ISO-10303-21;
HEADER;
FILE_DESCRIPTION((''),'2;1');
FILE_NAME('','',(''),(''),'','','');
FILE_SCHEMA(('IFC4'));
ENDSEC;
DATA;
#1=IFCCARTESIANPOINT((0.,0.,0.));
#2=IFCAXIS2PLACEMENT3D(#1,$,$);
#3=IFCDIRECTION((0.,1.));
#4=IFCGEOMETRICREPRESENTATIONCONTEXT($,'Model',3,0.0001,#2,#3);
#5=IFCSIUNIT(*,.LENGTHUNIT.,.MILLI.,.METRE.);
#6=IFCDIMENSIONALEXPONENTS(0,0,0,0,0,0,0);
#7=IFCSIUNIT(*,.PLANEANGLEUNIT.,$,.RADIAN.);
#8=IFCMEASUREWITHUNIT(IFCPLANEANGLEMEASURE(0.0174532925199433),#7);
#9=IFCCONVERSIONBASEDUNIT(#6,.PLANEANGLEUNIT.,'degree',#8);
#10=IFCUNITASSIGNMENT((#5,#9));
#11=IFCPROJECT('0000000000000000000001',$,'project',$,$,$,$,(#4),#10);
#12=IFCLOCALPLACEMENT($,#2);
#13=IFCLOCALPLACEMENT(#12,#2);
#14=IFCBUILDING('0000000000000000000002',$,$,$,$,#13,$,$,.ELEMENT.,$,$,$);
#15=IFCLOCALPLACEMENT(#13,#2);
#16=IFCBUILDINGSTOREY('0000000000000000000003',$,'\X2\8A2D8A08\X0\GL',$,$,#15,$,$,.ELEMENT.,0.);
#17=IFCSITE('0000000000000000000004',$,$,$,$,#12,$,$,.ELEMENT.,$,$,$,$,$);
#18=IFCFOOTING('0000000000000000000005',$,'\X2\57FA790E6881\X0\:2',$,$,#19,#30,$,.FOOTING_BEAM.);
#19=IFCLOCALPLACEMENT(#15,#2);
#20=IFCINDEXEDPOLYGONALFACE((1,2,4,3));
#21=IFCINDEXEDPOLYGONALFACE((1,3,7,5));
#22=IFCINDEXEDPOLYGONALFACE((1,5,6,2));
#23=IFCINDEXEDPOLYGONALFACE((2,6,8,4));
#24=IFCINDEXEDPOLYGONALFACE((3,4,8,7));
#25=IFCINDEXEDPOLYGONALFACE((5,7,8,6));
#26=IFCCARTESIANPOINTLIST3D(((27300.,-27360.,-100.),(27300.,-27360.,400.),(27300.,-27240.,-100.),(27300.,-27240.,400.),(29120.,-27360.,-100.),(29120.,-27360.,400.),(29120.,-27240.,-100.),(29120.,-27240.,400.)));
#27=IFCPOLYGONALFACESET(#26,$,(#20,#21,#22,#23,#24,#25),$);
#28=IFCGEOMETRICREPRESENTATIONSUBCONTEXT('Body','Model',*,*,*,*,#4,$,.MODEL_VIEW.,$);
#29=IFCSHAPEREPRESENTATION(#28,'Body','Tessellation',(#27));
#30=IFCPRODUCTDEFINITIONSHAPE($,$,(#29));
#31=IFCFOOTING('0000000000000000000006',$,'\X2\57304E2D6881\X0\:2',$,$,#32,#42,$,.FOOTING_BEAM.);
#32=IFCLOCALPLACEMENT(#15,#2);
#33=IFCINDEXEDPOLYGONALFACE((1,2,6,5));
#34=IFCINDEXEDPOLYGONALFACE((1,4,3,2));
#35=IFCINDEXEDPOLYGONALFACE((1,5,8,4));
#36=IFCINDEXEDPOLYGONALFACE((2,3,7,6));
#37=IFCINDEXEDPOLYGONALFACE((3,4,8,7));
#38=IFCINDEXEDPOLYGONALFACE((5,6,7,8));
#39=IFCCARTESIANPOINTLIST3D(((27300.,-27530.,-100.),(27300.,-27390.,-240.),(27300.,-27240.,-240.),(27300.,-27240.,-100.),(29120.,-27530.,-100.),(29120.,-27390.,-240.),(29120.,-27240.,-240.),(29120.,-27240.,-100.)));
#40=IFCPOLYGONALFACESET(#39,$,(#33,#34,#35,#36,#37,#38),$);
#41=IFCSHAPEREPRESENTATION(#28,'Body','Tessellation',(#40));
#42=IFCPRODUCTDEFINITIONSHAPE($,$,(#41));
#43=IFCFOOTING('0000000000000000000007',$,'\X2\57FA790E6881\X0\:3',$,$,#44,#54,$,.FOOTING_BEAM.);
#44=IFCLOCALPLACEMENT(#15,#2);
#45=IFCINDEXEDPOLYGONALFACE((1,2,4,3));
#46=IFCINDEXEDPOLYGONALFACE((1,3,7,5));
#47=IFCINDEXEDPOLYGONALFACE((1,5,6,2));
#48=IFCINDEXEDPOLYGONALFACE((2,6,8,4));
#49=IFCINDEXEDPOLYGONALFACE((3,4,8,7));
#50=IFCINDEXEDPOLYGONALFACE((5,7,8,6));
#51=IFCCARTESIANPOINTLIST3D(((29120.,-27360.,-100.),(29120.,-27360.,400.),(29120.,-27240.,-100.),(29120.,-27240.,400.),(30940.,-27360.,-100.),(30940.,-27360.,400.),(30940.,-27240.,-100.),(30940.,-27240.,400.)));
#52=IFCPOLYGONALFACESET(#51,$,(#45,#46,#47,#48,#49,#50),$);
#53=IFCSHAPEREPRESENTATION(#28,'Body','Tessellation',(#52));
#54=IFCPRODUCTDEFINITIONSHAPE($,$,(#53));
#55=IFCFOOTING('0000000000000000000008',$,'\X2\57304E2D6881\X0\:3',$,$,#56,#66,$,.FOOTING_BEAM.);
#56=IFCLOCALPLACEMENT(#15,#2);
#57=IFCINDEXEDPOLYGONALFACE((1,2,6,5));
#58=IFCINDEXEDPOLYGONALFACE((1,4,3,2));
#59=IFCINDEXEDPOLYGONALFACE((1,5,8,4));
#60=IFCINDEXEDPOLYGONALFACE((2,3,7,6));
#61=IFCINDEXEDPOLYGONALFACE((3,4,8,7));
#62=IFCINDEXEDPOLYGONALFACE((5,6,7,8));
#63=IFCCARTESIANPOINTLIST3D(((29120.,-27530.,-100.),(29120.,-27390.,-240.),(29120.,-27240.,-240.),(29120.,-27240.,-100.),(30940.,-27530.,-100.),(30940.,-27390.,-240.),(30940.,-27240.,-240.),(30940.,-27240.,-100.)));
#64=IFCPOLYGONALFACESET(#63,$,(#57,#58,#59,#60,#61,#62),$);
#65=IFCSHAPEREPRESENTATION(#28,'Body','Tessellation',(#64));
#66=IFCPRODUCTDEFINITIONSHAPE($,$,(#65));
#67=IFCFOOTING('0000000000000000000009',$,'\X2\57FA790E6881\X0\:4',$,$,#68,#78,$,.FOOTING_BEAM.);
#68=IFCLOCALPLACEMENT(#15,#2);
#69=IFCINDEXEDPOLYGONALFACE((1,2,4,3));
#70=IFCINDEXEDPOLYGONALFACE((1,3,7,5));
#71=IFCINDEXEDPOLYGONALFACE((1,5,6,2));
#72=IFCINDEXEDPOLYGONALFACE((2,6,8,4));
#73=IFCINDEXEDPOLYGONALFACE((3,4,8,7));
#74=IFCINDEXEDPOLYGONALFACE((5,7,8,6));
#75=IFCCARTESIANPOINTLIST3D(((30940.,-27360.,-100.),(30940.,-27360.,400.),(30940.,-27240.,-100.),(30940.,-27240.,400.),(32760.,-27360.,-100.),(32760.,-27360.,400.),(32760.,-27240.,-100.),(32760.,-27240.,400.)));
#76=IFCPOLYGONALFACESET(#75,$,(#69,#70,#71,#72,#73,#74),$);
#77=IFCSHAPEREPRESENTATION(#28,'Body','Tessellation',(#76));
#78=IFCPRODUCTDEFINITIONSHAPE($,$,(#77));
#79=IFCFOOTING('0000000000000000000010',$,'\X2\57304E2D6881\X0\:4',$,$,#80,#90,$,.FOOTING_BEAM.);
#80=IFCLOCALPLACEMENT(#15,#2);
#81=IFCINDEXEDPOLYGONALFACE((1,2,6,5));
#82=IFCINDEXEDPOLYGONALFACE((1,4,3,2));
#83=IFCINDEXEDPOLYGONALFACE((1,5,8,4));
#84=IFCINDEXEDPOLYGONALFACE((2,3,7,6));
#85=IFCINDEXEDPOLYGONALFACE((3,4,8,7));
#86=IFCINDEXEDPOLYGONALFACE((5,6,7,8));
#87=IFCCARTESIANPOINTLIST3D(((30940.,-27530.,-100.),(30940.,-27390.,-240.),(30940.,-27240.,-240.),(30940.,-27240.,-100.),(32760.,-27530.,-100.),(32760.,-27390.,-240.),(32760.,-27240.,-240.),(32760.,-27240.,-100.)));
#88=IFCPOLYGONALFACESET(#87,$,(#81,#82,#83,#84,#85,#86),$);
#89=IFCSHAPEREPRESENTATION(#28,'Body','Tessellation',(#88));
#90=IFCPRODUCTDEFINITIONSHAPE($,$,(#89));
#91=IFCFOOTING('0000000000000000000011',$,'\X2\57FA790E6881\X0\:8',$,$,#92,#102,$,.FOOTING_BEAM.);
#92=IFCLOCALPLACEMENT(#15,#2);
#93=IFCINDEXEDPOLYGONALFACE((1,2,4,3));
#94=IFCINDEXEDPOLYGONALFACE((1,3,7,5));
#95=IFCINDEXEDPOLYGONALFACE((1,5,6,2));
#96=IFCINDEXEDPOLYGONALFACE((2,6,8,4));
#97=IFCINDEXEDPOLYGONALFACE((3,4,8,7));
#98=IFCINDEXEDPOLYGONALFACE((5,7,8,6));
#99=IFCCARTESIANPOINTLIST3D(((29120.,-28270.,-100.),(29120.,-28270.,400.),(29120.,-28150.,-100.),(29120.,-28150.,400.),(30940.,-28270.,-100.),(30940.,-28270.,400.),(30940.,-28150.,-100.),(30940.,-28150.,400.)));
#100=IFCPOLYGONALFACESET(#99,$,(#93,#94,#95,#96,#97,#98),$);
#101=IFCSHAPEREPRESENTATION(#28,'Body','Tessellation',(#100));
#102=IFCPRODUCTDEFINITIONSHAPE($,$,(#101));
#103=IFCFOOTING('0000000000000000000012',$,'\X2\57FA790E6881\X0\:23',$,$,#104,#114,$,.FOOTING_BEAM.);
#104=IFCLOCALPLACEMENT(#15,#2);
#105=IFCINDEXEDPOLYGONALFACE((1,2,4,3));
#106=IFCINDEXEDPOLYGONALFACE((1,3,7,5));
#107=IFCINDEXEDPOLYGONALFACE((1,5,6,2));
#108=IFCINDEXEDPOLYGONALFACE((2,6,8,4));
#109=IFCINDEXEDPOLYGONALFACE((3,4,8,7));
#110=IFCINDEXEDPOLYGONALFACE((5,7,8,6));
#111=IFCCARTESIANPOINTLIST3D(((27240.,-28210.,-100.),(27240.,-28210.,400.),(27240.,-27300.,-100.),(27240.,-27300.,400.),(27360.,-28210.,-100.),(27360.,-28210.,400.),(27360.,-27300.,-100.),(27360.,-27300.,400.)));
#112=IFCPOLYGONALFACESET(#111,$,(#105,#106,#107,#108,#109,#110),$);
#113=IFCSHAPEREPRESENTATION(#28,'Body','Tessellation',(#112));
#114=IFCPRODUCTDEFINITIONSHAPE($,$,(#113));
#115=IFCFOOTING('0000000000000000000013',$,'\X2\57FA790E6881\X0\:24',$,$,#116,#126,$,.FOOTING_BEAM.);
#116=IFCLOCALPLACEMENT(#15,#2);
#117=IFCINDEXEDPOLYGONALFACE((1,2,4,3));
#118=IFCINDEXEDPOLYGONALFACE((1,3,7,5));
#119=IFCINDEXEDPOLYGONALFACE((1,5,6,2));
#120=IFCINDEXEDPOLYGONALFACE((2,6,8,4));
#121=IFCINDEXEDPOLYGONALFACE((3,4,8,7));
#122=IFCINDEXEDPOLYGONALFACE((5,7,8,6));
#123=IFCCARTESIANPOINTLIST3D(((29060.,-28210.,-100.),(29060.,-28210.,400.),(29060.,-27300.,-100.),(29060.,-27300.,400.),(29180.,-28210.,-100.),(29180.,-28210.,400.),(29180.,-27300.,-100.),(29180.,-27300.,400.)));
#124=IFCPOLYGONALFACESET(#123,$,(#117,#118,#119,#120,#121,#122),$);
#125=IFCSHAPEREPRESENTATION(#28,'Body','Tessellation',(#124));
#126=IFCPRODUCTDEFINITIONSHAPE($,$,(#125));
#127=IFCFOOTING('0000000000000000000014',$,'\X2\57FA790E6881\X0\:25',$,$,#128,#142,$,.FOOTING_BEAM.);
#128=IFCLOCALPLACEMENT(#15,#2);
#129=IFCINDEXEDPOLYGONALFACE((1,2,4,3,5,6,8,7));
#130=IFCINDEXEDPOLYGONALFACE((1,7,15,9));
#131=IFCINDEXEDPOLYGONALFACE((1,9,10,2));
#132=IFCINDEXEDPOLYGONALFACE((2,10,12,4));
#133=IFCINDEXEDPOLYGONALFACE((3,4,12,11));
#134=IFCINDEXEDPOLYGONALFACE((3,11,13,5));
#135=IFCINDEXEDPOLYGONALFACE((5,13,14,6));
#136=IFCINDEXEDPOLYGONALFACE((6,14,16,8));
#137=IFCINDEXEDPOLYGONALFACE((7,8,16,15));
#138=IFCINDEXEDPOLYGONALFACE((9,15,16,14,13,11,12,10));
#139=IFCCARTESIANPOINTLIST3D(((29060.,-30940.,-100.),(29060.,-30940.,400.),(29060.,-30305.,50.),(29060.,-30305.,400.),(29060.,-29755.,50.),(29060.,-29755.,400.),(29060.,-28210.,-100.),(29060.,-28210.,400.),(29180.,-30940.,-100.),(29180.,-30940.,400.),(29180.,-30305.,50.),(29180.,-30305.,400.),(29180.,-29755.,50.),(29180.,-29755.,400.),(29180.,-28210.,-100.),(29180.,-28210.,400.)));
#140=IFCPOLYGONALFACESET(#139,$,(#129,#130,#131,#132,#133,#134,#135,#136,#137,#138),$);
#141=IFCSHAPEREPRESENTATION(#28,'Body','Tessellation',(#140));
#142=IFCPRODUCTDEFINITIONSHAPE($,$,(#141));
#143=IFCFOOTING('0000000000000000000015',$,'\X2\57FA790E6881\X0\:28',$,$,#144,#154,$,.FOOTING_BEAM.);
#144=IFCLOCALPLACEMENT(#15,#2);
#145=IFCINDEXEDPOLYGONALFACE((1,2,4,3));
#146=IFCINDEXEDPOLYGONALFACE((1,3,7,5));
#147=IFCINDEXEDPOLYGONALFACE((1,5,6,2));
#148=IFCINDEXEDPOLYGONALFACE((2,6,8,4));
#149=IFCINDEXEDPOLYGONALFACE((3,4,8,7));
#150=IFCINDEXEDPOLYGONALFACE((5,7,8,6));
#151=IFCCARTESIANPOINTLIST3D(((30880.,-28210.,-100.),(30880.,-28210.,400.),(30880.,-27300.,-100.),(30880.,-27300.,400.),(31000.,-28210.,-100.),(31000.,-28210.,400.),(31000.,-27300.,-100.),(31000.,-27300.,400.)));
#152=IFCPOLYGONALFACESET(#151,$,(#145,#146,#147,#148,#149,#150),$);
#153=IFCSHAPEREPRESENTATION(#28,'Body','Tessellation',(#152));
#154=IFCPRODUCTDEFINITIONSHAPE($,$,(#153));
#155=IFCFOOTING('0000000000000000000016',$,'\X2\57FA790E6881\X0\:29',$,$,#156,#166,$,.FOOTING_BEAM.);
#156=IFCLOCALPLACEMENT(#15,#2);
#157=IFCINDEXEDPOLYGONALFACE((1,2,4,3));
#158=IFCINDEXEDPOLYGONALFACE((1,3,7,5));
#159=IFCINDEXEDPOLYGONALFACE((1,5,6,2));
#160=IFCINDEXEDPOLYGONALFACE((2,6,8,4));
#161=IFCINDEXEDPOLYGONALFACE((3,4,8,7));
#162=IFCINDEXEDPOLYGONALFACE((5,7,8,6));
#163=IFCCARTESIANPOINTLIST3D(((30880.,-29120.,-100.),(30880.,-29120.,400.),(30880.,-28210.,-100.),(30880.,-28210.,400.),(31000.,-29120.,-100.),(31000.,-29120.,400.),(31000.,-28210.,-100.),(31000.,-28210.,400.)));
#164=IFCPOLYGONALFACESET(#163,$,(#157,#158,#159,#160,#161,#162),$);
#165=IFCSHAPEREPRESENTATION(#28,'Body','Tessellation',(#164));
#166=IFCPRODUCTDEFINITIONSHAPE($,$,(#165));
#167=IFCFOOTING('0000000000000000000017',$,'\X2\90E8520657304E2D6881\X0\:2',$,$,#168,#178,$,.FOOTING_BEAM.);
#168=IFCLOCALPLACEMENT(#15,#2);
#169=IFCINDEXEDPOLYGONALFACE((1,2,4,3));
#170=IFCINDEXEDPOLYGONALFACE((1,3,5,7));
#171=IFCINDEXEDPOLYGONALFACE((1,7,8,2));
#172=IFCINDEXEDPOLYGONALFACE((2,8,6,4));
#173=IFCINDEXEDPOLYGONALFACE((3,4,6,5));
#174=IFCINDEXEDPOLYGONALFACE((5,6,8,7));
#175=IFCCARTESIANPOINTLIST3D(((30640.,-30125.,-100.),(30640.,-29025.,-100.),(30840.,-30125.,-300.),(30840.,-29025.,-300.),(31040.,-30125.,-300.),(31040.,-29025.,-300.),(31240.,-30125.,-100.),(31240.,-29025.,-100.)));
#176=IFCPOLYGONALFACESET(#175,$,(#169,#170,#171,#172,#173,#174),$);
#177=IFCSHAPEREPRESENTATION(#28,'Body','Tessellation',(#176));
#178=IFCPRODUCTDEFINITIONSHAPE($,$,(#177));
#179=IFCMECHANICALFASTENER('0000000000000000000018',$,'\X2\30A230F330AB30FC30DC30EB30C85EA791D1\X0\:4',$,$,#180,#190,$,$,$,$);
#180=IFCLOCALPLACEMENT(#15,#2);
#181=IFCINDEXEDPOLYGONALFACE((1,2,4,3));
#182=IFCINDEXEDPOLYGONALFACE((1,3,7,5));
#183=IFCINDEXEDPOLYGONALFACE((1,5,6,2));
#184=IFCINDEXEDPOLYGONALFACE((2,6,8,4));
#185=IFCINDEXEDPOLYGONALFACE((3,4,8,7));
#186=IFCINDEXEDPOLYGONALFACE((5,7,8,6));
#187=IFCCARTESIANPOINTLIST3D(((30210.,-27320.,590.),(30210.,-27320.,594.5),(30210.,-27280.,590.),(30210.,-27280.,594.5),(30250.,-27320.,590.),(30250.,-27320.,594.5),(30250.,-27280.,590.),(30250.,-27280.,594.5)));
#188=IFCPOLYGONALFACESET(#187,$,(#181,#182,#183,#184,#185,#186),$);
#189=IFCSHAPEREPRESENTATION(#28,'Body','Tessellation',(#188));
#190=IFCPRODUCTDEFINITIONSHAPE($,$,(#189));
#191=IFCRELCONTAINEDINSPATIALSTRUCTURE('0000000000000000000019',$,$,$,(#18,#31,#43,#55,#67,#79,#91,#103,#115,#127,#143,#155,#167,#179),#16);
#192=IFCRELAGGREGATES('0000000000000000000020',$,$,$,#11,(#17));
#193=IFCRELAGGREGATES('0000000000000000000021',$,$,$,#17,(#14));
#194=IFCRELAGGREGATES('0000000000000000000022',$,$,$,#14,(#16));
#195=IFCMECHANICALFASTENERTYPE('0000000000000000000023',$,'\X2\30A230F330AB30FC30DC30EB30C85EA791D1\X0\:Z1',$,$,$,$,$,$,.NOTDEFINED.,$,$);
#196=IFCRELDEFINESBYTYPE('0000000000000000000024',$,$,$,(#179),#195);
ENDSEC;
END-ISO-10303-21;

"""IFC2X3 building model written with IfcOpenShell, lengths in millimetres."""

from ifc_helpers import new_model, entity, si_unit, converted_unit, direction, frame, origin, origin_with_axes, origin_2d, place, context, subcontext, project, spatial, polyline, rectangle, outline, extrude, boolean, type_object, element, save


model = new_model("IFC2X3")

# Units and contexts
model_context = context("Model", 3, precision=0.0001, world=origin(), true_north=direction((0.0, 1.0)))
body_context = subcontext(model_context, "Body", "Model", "MODEL_VIEW")
ifc_project = project(units=[si_unit("LENGTHUNIT", "METRE", prefix="MILLI"), converted_unit("PLANEANGLEUNIT", "degree", entity("IfcPlaneAngleMeasure", 0.0174532925199433), si_unit("PLANEANGLEUNIT", "RADIAN"), dimensions=[0, 0, 0, 0, 0, 0, 0])], contexts=[model_context])

# Site, building, storey
site_placement = place(None, origin())
site = spatial("IfcSite", under=ifc_project, at=site_placement, CompositionType="ELEMENT")
building_placement = place(site_placement, origin())
building = spatial("IfcBuilding", under=site, at=building_placement, CompositionType="ELEMENT")
storey_placement = place(building_placement, origin())
storey = spatial("IfcBuildingStorey", under=building, at=storey_placement, Name="設計GL", CompositionType="ELEMENT", Elevation=0.0)

# Footings
footing_1_placement = place(storey_placement, frame((27300.0, -27300.0, 150.0), z_axis=(1.0, 0.0, 0.0), x_axis=(0.0, 1.0, 0.0)))
element("IfcFooting", 1, at=footing_1_placement, inside=storey, Name="基礎梁:2", PredefinedType="FOOTING_BEAM", context=body_context, shape_type="SolidModel", body=[
    extrude(rectangle(XDim=120.0, YDim=500.0, at=origin_2d()), origin_with_axes(), (0.0, 0.0, 1.0), 1820.0),
])
footing_2_placement = place(storey_placement, frame((27300.0, -27240.0, -240.0), z_axis=(1.0, 0.0, 0.0), x_axis=(0.0, 1.0, 0.0)))
element("IfcFooting", 2, at=footing_2_placement, inside=storey, Name="地中梁:2", PredefinedType="FOOTING_BEAM", context=body_context, shape_type="SweptSolid", body=[
    extrude(outline(polyline([(0.0, 0.0, 0.0), (-150.0, 0.0, 0.0), (-290.0, 140.0, 0.0), (0.0, 140.0, 0.0), (0.0, 0.0, 0.0)])), origin_with_axes(), (0.0, 0.0, 1.0), 1820.0),
])
footing_3_placement = place(storey_placement, frame((29120.0, -27300.0, 150.0), z_axis=(1.0, 0.0, 0.0), x_axis=(0.0, 1.0, 0.0)))
element("IfcFooting", 3, at=footing_3_placement, inside=storey, Name="基礎梁:3", PredefinedType="FOOTING_BEAM", context=body_context, shape_type="SolidModel", body=[
    extrude(rectangle(XDim=120.0, YDim=500.0, at=origin_2d()), origin_with_axes(), (0.0, 0.0, 1.0), 1820.0),
])
footing_4_placement = place(storey_placement, frame((29120.0, -27240.0, -240.0), z_axis=(1.0, 0.0, 0.0), x_axis=(0.0, 1.0, 0.0)))
element("IfcFooting", 4, at=footing_4_placement, inside=storey, Name="地中梁:3", PredefinedType="FOOTING_BEAM", context=body_context, shape_type="SweptSolid", body=[
    extrude(outline(polyline([(0.0, 0.0, 0.0), (-150.0, 0.0, 0.0), (-290.0, 140.0, 0.0), (0.0, 140.0, 0.0), (0.0, 0.0, 0.0)])), origin_with_axes(), (0.0, 0.0, 1.0), 1820.0),
])
footing_5_placement = place(storey_placement, frame((30940.0, -27300.0, 150.0), z_axis=(1.0, 0.0, 0.0), x_axis=(0.0, 1.0, 0.0)))
element("IfcFooting", 5, at=footing_5_placement, inside=storey, Name="基礎梁:4", PredefinedType="FOOTING_BEAM", context=body_context, shape_type="SolidModel", body=[
    extrude(rectangle(XDim=120.0, YDim=500.0, at=origin_2d()), origin_with_axes(), (0.0, 0.0, 1.0), 1820.0),
])
footing_6_placement = place(storey_placement, frame((30940.0, -27240.0, -240.0), z_axis=(1.0, 0.0, 0.0), x_axis=(0.0, 1.0, 0.0)))
element("IfcFooting", 6, at=footing_6_placement, inside=storey, Name="地中梁:4", PredefinedType="FOOTING_BEAM", context=body_context, shape_type="SweptSolid", body=[
    extrude(outline(polyline([(0.0, 0.0, 0.0), (-150.0, 0.0, 0.0), (-290.0, 140.0, 0.0), (0.0, 140.0, 0.0), (0.0, 0.0, 0.0)])), origin_with_axes(), (0.0, 0.0, 1.0), 1820.0),
])
footing_7_placement = place(storey_placement, frame((29120.0, -28210.0, 150.0), z_axis=(1.0, 0.0, 0.0), x_axis=(0.0, 1.0, 0.0)))
element("IfcFooting", 7, at=footing_7_placement, inside=storey, Name="基礎梁:8", PredefinedType="FOOTING_BEAM", context=body_context, shape_type="SolidModel", body=[
    extrude(rectangle(XDim=120.0, YDim=500.0, at=origin_2d()), origin_with_axes(), (0.0, 0.0, 1.0), 1820.0),
])
for number, where, z_axis, x_axis, name in (
    (8, (27300.0, -27300.0, 150.0), (0.0, -1.0, 0.0), (1.0, 0.0, 0.0), "基礎梁:23"),
    (9, (29120.0, -27300.0, 150.0), (0.0, -1.0, 0.0), (1.0, 0.0, 0.0), "基礎梁:24"),
):
    element("IfcFooting", number, at=place(storey_placement, frame(where, z_axis=z_axis, x_axis=x_axis)), inside=storey, Name=name, PredefinedType="FOOTING_BEAM", context=body_context, shape_type="SolidModel", body=[
        extrude(rectangle(XDim=120.0, YDim=500.0, at=origin_2d()), origin_with_axes(), (0.0, 0.0, 1.0), 910.0),
    ])
footing_8_placement = place(storey_placement, frame((29120.0, -28210.0, 150.0), z_axis=(0.0, -1.0, 0.0), x_axis=(1.0, 0.0, 0.0)))
element("IfcFooting", 10, at=footing_8_placement, inside=storey, Name="基礎梁:25", PredefinedType="FOOTING_BEAM", context=body_context, shape_type="CSG", body=[
    boolean("DIFFERENCE", extrude(rectangle(XDim=120.0, YDim=500.0, at=origin_2d()), origin_with_axes(), (0.0, 0.0, 1.0), 2730.0), extrude(rectangle(XDim=124.0, YDim=350.0, at=origin_2d()), frame((0.0, 75.0, 1545.0), z_axis=(0.0, 0.0, 1.0), x_axis=(1.0, 0.0, 0.0)), (0.0, 0.0, 1.0), 550.0)),
])
for number, where, z_axis, x_axis, name in (
    (11, (30940.0, -27300.0, 150.0), (0.0, -1.0, 0.0), (1.0, 0.0, 0.0), "基礎梁:28"),
    (12, (30940.0, -28210.0, 150.0), (0.0, -1.0, 0.0), (1.0, 0.0, 0.0), "基礎梁:29"),
):
    element("IfcFooting", number, at=place(storey_placement, frame(where, z_axis=z_axis, x_axis=x_axis)), inside=storey, Name=name, PredefinedType="FOOTING_BEAM", context=body_context, shape_type="SolidModel", body=[
        extrude(rectangle(XDim=120.0, YDim=500.0, at=origin_2d()), origin_with_axes(), (0.0, 0.0, 1.0), 910.0),
    ])
footing_9_placement = place(storey_placement, frame((30940.0, -29025.0, -300.0), z_axis=(0.0, -1.0, 0.0), x_axis=(1.0, 0.0, 0.0)))
element("IfcFooting", 13, at=footing_9_placement, inside=storey, Name="部分地中梁:2", PredefinedType="FOOTING_BEAM", context=body_context, shape_type="SweptSolid", body=[
    extrude(outline(polyline([(-100.0, 0.0, 0.0), (100.0, 0.0, 0.0), (300.0, 200.0, 0.0), (-300.0, 200.0, 0.0), (-100.0, 0.0, 0.0)])), origin_with_axes(), (0.0, 0.0, 1.0), 1100.0),
])

# Mechanical fastener
mechanical_fastener_type_1 = type_object("IfcMechanicalFastenerType", Name="アンカーボルト座金:Z1")
mechanical_fastener_1_placement = place(storey_placement, frame((30230.0, -27300.0, 590.0)))
element("IfcMechanicalFastener", 14, at=mechanical_fastener_1_placement, inside=storey, type_object=mechanical_fastener_type_1, Name="アンカーボルト座金:4", context=body_context, shape_type="SweptSolid", body=[
    extrude(rectangle(XDim=40.0, YDim=40.0, at=origin_2d()), origin_with_axes(), (0.0, 0.0, 1.0), 4.5),
])

save(model, "model.ifc")
